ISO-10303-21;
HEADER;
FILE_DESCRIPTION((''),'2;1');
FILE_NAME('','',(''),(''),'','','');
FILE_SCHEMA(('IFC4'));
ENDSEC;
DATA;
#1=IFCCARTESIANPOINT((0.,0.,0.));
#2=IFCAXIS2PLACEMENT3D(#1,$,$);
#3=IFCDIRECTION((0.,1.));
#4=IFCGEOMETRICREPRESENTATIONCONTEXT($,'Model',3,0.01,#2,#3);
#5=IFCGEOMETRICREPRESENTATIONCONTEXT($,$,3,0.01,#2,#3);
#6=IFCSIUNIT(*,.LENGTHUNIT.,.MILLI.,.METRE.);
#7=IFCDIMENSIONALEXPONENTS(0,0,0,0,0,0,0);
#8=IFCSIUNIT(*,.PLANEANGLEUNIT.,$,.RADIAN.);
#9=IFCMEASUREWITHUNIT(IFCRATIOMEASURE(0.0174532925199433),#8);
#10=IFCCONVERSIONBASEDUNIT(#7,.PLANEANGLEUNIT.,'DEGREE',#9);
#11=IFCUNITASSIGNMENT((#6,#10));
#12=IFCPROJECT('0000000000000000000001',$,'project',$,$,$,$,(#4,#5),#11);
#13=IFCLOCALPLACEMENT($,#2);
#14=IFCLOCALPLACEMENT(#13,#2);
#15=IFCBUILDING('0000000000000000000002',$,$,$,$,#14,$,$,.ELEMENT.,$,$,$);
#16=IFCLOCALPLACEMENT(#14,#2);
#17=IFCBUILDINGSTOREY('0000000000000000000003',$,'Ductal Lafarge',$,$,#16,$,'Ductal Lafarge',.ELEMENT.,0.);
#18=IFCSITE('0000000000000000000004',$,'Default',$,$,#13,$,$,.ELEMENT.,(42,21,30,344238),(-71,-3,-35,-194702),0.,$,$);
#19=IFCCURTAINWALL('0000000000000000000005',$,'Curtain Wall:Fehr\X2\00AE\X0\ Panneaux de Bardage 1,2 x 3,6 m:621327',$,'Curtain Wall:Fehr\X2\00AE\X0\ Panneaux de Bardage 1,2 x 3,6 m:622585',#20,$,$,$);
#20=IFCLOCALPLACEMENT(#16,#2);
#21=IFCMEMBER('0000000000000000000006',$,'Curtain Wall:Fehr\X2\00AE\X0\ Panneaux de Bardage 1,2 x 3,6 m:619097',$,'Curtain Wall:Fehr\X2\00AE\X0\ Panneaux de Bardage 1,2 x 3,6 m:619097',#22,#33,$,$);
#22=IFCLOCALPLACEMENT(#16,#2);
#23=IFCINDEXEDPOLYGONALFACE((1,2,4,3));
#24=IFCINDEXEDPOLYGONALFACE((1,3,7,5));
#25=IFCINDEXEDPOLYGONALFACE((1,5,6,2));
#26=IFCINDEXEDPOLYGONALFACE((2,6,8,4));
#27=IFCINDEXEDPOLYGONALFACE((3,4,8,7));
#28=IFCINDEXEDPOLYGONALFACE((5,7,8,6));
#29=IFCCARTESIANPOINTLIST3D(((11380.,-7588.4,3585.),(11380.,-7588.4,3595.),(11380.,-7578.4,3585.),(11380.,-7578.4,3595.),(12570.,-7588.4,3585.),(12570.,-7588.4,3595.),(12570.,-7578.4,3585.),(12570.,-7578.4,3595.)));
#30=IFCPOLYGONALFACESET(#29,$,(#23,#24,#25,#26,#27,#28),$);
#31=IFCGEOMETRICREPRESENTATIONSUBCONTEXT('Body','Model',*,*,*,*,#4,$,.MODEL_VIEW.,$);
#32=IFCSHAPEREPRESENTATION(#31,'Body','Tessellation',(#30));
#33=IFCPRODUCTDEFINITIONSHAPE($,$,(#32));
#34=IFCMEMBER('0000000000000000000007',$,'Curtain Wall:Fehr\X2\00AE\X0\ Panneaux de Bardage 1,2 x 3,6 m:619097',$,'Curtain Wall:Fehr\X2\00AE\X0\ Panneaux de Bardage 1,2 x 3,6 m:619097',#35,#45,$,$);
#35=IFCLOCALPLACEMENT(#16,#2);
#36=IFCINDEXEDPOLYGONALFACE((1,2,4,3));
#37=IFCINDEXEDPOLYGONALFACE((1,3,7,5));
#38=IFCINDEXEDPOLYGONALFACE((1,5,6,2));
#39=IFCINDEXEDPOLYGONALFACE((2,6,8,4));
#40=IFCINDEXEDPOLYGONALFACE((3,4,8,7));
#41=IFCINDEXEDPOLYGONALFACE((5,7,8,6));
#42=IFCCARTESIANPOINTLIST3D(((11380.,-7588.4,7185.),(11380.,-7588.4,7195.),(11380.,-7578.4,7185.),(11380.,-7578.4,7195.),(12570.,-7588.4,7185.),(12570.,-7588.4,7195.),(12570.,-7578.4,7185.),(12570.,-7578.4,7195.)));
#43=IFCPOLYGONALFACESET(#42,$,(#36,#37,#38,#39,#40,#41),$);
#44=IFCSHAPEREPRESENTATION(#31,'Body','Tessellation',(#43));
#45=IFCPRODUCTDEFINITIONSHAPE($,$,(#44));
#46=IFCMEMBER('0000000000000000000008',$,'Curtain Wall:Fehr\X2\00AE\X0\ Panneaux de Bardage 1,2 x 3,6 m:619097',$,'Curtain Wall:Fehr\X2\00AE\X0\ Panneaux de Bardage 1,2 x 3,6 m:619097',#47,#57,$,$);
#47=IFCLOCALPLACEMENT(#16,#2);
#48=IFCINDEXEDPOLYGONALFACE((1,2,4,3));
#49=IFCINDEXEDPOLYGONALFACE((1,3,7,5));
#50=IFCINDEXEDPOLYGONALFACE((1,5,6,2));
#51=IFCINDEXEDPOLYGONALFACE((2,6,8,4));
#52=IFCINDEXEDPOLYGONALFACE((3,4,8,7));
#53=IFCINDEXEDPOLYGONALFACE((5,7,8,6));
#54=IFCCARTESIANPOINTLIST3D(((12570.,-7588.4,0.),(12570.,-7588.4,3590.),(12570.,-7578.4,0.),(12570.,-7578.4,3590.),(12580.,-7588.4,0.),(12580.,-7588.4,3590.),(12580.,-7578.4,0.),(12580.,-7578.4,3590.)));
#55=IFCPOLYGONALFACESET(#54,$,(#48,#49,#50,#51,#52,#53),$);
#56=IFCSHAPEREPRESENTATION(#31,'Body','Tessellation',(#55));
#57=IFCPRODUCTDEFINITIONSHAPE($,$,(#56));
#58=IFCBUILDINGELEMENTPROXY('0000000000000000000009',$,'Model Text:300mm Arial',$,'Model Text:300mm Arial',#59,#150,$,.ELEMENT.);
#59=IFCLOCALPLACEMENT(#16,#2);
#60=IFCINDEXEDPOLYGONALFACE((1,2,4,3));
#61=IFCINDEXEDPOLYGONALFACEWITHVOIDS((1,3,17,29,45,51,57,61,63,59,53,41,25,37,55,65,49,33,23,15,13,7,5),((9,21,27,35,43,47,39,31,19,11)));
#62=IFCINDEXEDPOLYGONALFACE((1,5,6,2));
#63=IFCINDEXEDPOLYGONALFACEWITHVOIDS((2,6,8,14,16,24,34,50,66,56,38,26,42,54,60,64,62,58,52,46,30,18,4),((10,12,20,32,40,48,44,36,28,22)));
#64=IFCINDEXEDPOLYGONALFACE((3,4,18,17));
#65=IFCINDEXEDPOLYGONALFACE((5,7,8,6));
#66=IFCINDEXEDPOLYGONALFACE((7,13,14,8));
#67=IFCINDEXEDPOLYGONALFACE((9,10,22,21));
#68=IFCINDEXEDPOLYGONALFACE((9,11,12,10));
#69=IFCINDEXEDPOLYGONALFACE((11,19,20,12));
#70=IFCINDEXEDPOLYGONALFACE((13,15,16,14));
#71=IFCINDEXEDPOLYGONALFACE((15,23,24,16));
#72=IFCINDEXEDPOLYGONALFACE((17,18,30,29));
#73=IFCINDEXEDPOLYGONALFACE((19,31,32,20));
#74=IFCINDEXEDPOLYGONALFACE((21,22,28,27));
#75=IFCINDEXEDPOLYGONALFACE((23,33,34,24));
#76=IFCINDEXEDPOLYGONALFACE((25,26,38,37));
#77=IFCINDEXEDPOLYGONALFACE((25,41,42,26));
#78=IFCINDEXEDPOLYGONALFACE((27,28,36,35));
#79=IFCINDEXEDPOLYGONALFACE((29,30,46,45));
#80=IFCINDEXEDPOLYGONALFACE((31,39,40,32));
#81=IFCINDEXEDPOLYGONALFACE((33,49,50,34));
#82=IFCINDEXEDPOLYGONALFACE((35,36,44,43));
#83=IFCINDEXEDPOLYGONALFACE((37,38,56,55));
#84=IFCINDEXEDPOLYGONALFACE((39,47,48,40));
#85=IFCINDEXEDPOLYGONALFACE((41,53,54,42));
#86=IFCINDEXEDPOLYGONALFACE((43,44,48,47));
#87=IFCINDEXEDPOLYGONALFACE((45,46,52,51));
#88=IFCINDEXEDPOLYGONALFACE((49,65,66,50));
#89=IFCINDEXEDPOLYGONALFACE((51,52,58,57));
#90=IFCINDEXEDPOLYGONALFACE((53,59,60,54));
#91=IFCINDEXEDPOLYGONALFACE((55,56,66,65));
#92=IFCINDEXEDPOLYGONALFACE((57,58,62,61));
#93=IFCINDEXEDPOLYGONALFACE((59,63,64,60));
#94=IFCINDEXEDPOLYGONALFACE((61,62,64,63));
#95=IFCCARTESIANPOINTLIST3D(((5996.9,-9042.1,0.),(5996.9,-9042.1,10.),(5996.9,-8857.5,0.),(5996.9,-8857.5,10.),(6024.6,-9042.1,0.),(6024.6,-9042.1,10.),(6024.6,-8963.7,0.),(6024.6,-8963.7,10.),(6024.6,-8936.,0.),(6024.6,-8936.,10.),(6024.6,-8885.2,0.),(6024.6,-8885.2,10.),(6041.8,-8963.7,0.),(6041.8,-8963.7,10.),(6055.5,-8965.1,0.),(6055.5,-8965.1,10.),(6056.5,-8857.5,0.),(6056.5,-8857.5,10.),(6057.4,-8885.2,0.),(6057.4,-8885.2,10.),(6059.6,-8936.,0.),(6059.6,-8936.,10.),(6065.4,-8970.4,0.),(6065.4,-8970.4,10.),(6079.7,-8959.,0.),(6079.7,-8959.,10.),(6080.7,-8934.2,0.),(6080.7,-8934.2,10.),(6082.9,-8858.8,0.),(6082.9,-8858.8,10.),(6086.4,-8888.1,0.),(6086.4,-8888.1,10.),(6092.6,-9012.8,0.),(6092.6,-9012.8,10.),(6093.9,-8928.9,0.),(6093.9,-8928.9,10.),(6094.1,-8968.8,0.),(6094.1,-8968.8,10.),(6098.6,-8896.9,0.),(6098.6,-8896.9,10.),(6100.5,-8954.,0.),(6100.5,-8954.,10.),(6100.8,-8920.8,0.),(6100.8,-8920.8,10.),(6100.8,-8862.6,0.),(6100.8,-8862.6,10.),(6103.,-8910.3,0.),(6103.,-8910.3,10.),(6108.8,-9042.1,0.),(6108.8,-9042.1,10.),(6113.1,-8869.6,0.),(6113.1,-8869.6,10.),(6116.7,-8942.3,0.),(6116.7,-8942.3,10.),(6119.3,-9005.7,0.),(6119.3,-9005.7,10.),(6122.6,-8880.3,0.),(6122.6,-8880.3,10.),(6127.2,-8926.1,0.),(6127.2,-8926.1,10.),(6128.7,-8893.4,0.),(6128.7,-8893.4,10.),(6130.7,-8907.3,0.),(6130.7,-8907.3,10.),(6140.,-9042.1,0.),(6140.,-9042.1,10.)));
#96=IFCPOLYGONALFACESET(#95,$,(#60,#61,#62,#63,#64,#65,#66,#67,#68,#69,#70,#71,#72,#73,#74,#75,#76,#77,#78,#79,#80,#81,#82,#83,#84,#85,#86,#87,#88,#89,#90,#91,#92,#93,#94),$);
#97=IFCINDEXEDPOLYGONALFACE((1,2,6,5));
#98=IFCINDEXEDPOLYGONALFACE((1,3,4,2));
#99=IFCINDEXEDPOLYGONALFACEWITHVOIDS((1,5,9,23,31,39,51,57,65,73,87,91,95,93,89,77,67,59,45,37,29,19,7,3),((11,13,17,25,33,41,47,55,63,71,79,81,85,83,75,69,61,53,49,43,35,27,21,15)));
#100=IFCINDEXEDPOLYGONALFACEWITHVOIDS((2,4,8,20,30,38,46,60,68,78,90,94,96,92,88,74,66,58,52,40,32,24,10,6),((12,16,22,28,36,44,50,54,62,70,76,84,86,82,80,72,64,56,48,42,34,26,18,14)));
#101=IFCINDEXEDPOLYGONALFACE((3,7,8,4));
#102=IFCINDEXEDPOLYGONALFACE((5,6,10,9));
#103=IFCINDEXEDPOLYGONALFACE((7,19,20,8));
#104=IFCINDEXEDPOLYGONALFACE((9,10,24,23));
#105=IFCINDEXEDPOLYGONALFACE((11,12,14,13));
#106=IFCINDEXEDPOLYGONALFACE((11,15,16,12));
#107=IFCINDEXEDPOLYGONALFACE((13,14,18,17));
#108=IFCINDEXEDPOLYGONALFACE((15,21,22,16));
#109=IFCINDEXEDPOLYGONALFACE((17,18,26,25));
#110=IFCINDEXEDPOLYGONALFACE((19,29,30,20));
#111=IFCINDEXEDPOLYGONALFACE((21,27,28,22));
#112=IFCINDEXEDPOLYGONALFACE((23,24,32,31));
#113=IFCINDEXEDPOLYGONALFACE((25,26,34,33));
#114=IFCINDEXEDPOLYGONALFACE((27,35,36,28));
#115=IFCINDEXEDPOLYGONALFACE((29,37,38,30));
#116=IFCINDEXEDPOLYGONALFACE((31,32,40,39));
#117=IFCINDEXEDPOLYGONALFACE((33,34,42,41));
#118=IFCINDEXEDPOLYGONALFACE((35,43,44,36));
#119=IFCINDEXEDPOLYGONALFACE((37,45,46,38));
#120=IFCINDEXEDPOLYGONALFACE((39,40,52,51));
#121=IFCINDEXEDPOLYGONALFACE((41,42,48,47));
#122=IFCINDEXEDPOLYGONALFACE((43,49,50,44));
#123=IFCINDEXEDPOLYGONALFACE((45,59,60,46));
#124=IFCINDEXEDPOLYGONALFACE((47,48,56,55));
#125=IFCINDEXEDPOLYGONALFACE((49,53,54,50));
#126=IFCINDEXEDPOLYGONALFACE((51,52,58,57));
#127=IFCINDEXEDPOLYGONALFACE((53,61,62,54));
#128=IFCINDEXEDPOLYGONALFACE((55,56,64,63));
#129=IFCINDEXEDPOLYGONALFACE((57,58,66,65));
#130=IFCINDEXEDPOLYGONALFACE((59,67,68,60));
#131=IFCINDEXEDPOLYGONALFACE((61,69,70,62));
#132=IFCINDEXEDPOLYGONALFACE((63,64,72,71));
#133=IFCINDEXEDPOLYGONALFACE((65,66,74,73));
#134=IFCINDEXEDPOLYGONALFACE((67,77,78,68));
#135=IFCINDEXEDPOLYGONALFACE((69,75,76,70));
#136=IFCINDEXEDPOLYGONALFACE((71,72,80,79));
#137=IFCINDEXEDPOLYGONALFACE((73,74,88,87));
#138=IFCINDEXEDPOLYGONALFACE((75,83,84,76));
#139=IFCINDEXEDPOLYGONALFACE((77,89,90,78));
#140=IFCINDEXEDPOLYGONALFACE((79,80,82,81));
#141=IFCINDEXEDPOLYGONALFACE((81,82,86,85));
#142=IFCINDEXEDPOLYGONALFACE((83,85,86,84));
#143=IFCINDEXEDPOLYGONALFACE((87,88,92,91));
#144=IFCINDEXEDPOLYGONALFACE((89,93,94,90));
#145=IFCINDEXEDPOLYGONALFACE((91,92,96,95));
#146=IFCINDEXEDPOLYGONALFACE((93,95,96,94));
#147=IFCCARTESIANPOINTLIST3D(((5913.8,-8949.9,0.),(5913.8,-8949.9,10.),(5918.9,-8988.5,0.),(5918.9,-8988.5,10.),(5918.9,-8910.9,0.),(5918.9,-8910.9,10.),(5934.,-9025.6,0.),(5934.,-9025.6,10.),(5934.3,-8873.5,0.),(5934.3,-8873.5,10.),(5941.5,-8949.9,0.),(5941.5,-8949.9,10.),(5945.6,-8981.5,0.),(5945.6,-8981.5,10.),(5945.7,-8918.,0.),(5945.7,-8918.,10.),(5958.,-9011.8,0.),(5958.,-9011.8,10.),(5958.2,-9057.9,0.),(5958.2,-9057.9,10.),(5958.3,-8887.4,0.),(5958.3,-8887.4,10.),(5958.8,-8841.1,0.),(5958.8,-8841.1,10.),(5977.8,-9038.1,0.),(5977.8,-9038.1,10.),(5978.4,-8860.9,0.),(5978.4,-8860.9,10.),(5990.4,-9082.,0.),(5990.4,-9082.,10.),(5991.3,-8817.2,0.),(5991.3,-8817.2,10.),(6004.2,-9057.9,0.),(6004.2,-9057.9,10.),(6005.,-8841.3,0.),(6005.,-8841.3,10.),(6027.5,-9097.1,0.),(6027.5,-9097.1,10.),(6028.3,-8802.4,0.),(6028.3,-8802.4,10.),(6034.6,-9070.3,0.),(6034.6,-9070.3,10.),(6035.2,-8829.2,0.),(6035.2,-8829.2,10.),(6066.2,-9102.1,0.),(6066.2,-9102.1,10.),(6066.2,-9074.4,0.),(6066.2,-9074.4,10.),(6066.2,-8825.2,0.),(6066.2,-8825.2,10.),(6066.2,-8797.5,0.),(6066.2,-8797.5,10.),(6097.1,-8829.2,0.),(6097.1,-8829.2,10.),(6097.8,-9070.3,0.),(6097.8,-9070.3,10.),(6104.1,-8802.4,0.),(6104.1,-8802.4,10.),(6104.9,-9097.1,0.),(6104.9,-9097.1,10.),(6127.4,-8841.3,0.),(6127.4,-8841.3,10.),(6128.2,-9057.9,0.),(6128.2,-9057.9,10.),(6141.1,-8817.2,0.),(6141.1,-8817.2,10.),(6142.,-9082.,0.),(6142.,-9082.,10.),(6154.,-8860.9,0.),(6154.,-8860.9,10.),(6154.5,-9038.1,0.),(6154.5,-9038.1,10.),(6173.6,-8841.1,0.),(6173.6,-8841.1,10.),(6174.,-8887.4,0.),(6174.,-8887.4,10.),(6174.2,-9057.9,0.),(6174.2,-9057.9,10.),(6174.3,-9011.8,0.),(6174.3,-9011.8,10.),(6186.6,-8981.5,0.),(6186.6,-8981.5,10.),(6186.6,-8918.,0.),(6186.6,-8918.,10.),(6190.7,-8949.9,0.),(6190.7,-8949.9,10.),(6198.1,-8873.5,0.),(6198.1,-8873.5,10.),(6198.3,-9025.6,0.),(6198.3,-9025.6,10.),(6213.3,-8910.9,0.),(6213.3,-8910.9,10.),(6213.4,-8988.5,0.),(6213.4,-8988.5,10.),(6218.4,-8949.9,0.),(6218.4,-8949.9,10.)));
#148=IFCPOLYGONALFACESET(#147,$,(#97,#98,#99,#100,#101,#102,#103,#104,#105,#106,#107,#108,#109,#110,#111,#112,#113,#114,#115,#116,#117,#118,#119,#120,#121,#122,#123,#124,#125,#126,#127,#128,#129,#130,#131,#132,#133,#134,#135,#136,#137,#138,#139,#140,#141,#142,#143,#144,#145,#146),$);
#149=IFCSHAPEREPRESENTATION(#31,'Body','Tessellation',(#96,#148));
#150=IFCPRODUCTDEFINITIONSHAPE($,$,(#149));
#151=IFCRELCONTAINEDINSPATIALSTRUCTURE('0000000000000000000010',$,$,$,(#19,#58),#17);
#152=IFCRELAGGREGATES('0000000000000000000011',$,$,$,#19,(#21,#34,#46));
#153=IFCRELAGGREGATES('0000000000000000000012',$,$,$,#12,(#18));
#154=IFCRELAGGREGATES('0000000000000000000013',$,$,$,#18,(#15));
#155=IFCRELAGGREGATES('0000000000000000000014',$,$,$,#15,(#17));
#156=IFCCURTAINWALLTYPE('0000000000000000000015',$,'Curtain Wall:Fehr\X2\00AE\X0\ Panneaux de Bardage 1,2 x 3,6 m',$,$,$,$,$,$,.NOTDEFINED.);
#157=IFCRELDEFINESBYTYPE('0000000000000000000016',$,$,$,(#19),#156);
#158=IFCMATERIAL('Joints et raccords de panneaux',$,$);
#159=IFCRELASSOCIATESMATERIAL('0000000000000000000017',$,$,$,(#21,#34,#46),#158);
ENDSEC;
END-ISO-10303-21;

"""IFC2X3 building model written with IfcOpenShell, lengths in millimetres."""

from ifc_helpers import new_model, entity, si_unit, converted_unit, direction, frame, frame_2d, origin, place, context, subcontext, project, spatial, polyline, rectangle, outline, extrude, material, type_object, element, aggregate, save


model = new_model("IFC2X3")

# Units and contexts
model_context = context("Model", 3, precision=0.01, world=origin(), true_north=direction((0.0, 1.0)))
context_of_model = context(None, 3, precision=0.01, world=origin(), true_north=direction((0.0, 1.0)))
body_context = subcontext(model_context, "Body", "Model", "MODEL_VIEW")
ifc_project = project(units=[si_unit("LENGTHUNIT", "METRE", prefix="MILLI"), converted_unit("PLANEANGLEUNIT", "DEGREE", entity("IfcRatioMeasure", 0.0174532925199433), si_unit("PLANEANGLEUNIT", "RADIAN"), dimensions=[0, 0, 0, 0, 0, 0, 0])], contexts=[model_context, context_of_model])

# Site, building, storey
site_placement = place(None, origin())
site = spatial("IfcSite", under=ifc_project, at=site_placement, Name="Default", CompositionType="ELEMENT", RefLatitude=(42, 21, 30, 344238), RefLongitude=(-71, -3, -35, -194702), RefElevation=0.0)
building_placement = place(site_placement, origin())
building = spatial("IfcBuilding", under=site, at=building_placement, CompositionType="ELEMENT")
storey_placement = place(building_placement, origin())
storey = spatial("IfcBuildingStorey", under=building, at=storey_placement, Name="Ductal Lafarge", LongName="Ductal Lafarge", CompositionType="ELEMENT", Elevation=0.0)

# Curtain wall, members
curtain_wall_type = type_object("IfcCurtainWallType", Name="Curtain Wall:Fehr® Panneaux de Bardage 1,2 x 3,6 m", PredefinedType="NOTDEFINED")
curtain_wall_placement = place(storey_placement, origin())
curtain_wall = element("IfcCurtainWall", 1, at=curtain_wall_placement, inside=storey, type_object=curtain_wall_type, Name="Curtain Wall:Fehr® Panneaux de Bardage 1,2 x 3,6 m:621327", ObjectType="Curtain Wall:Fehr® Panneaux de Bardage 1,2 x 3,6 m:622585")
ifc_material = material(Name="Joints et raccords de panneaux")
member_1_placement = place(curtain_wall_placement, frame((11380.0, -7588.4, 3585.0)))
member_1 = element("IfcMember", 2, at=member_1_placement, material=ifc_material, Name="Curtain Wall:Fehr® Panneaux de Bardage 1,2 x 3,6 m:619097", ObjectType="Curtain Wall:Fehr® Panneaux de Bardage 1,2 x 3,6 m:619097", context=body_context, shape_type="SweptSolid", body=[
    extrude(rectangle(XDim=1190.0, YDim=10.0, at=frame_2d((0.0, 0.0), x_axis=(1.0, 0.0))), frame((595.0, 5.0, 0.0), z_axis=(0.0, 0.0, 1.0), x_axis=(-1.0, 0.0, 0.0)), (0.0, 0.0, 1.0), 10.0),
])
member_2_placement = place(curtain_wall_placement, frame((11380.0, -7588.4, 7185.0)))
member_2 = element("IfcMember", 3, at=member_2_placement, material=ifc_material, Name="Curtain Wall:Fehr® Panneaux de Bardage 1,2 x 3,6 m:619097", ObjectType="Curtain Wall:Fehr® Panneaux de Bardage 1,2 x 3,6 m:619097", context=body_context, shape_type="SweptSolid", body=[
    extrude(rectangle(XDim=1190.0, YDim=10.0, at=frame_2d((0.0, 0.0), x_axis=(1.0, 0.0))), frame((595.0, 5.0, 0.0), z_axis=(0.0, 0.0, 1.0), x_axis=(-1.0, 0.0, 0.0)), (0.0, 0.0, 1.0), 10.0),
])
member_3_placement = place(curtain_wall_placement, frame((12570.0, -7588.4, 0.0)))
member_3 = element("IfcMember", 4, at=member_3_placement, material=ifc_material, Name="Curtain Wall:Fehr® Panneaux de Bardage 1,2 x 3,6 m:619097", ObjectType="Curtain Wall:Fehr® Panneaux de Bardage 1,2 x 3,6 m:619097", context=body_context, shape_type="SweptSolid", body=[
    extrude(rectangle(XDim=10.0, YDim=10.0, at=frame_2d((0.0, 0.0), x_axis=(1.0, 0.0))), frame((5.0, 5.0, 0.0), z_axis=(0.0, 0.0, 1.0), x_axis=(0.0, 1.0, 0.0)), (0.0, 0.0, 1.0), 3590.0),
])
aggregate(curtain_wall, [member_1, member_2, member_3])

# Building element proxy
proxy_1_placement = place(storey_placement, frame((5913.8, -9102.1, 0.0)))
element("IfcBuildingElementProxy", 5, at=proxy_1_placement, inside=storey, Name="Model Text:300mm Arial", ObjectType="Model Text:300mm Arial", CompositionType="ELEMENT", context=body_context, shape_type="SweptSolid", body=[
    extrude(outline(polyline([(-86.6, -94.9), (-58.9, -94.9), (-58.9, -16.4), (-41.7, -16.4), (-28.0, -17.8), (-18.1, -23.2), (9.1, -65.6), (25.3, -94.9), (56.5, -94.9), (35.8, -58.4), (10.6, -21.6), (-3.8, -11.8), (17.0, -6.7), (33.3, 5.0), (43.8, 21.2), (47.3, 40.0), (45.2, 53.9), (39.1, 66.9), (29.6, 77.7), (17.3, 84.7), (-0.6, 88.5), (-26.9, 89.8), (-86.6, 89.8), (-86.6, -94.9)]), holes=[polyline([(-58.9, 11.3), (-58.9, 62.1), (-26.1, 62.1), (2.9, 59.2), (15.2, 50.4), (19.6, 37.0), (17.3, 26.5), (10.4, 18.3), (-2.7, 13.1), (-23.8, 11.3), (-58.9, 11.3)])]), frame((169.7, 154.9, 0.0)), (0.0, 0.0, 1.0), 10.0),
    extrude(outline(polyline([(-19.6, -150.9), (18.6, -150.9), (57.1, -141.0), (92.5, -121.5), (121.0, -92.5), (141.0, -57.4), (151.1, -19.4), (151.1, 19.5), (140.9, 58.3), (121.0, 93.4), (92.2, 121.5), (57.4, 141.2), (19.6, 151.2), (-19.4, 151.2), (-58.1, 141.0), (-93.2, 121.2), (-121.3, 92.3), (-141.0, 57.5), (-150.9, 19.8), (-150.9, -19.4), (-140.6, -58.5), (-120.5, -93.8), (-91.4, -121.7), (-56.6, -141.1), (-19.6, -150.9)]), holes=[polyline([(-16.1, -123.4), (-46.2, -115.4), (-74.7, -99.6), (-98.5, -76.7), (-114.9, -47.8), (-123.4, -15.8), (-123.5, 16.3), (-115.3, 47.1), (-99.2, 75.5), (-76.2, 99.1), (-47.5, 115.3), (-15.8, 123.7), (16.1, 123.7), (46.9, 115.6), (75.4, 99.4), (99.0, 76.3), (115.3, 47.7), (123.7, 16.0), (123.7, -15.9), (115.4, -46.9), (98.9, -75.6), (75.6, -99.3), (46.7, -115.3), (15.2, -123.4), (-16.1, -123.4)])]), frame((152.4, 152.5, 0.0), z_axis=(0.0, 0.0, 1.0), x_axis=(-0.991656, -0.128915, 0.0)), (0.0, 0.0, 1.0), 10.0),
])

save(model, "model.ifc")
